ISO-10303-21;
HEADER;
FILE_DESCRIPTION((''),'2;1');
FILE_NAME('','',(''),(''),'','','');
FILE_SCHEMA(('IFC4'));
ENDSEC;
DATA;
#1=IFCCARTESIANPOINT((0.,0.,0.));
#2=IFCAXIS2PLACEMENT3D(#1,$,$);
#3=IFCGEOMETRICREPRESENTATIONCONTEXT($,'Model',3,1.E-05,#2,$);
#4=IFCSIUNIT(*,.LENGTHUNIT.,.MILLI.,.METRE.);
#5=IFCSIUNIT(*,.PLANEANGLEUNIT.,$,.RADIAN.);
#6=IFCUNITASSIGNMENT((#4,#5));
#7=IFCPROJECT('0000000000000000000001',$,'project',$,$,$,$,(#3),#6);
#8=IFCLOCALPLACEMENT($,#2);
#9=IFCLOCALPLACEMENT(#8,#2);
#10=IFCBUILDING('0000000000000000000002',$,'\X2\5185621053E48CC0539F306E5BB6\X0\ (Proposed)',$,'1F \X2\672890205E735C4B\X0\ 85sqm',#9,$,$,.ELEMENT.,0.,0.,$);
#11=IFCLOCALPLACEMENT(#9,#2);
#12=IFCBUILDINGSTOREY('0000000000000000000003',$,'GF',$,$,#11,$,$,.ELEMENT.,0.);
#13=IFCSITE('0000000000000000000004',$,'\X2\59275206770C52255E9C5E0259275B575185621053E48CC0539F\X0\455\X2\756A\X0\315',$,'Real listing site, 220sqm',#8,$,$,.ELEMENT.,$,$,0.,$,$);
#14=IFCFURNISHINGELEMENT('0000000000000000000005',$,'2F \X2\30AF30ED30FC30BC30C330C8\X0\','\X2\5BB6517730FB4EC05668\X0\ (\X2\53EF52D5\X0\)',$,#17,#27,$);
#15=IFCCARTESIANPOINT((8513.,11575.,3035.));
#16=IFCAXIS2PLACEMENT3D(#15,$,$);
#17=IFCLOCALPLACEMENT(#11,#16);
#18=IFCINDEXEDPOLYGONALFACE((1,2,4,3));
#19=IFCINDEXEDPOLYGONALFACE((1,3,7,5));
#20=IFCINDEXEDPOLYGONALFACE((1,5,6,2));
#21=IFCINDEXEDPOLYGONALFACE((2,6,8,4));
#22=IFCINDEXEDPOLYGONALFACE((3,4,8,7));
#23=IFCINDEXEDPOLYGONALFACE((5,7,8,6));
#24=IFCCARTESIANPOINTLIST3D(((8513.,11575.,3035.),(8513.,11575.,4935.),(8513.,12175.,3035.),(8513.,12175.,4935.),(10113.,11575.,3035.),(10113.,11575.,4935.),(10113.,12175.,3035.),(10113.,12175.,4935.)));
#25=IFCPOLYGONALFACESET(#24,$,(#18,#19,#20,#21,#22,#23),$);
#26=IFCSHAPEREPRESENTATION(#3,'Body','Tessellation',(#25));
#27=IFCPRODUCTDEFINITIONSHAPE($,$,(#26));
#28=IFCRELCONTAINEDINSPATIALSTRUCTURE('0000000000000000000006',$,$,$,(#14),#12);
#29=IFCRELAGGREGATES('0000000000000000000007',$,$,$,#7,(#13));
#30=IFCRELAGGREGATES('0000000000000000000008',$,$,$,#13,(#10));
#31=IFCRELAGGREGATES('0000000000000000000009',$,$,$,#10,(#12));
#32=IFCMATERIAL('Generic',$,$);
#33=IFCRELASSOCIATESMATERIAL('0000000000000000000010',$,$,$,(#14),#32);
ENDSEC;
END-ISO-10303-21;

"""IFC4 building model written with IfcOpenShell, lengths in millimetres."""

from ifc_helpers import new_model, si_unit, frame, frame_2d, origin, place, context, project, spatial, rectangle, extrude, material, element, save


model = new_model("IFC4")

# Units and contexts
model_context = context("Model", 3, precision=1e-05, world=origin())
ifc_project = project(units=[si_unit("LENGTHUNIT", "METRE", prefix="MILLI"), si_unit("PLANEANGLEUNIT", "RADIAN")], contexts=[model_context])

# Site, building, storey
site_placement = place(None, origin())
site = spatial("IfcSite", under=ifc_project, at=site_placement, Name="大分県別府市大字内成古賀原455番315", ObjectType="Real listing site, 220sqm", CompositionType="ELEMENT", RefElevation=0.0)
building_placement = place(site_placement, origin())
building = spatial("IfcBuilding", under=site, at=building_placement, Name="内成古賀原の家 (Proposed)", ObjectType="1F 木造平屋 85sqm", CompositionType="ELEMENT", ElevationOfRefHeight=0.0, ElevationOfTerrain=0.0)
storey_placement = place(building_placement, origin())
storey = spatial("IfcBuildingStorey", under=building, at=storey_placement, Name="GF", CompositionType="ELEMENT", Elevation=0.0)

# Shared definitions
ifc_material_1 = material(Name="Generic")

# Furnishing element
furnishing_1_placement = place(storey_placement, frame((8513.0, 11575.0, 3035.0)))
element("IfcFurnishingElement", 1, at=furnishing_1_placement, inside=storey, material=ifc_material_1, Name="2F クローゼット", Description="家具・什器 (可動)", context=model_context, shape_type="SweptSolid", body=[
    extrude(rectangle(XDim=1600.0, YDim=600.0, at=frame_2d((800.0, 300.0))), frame((8513.0, 11575.0, 3035.0)), (0.0, 0.0, 1.0), 1900.0),
])

save(model, "model.ifc")
